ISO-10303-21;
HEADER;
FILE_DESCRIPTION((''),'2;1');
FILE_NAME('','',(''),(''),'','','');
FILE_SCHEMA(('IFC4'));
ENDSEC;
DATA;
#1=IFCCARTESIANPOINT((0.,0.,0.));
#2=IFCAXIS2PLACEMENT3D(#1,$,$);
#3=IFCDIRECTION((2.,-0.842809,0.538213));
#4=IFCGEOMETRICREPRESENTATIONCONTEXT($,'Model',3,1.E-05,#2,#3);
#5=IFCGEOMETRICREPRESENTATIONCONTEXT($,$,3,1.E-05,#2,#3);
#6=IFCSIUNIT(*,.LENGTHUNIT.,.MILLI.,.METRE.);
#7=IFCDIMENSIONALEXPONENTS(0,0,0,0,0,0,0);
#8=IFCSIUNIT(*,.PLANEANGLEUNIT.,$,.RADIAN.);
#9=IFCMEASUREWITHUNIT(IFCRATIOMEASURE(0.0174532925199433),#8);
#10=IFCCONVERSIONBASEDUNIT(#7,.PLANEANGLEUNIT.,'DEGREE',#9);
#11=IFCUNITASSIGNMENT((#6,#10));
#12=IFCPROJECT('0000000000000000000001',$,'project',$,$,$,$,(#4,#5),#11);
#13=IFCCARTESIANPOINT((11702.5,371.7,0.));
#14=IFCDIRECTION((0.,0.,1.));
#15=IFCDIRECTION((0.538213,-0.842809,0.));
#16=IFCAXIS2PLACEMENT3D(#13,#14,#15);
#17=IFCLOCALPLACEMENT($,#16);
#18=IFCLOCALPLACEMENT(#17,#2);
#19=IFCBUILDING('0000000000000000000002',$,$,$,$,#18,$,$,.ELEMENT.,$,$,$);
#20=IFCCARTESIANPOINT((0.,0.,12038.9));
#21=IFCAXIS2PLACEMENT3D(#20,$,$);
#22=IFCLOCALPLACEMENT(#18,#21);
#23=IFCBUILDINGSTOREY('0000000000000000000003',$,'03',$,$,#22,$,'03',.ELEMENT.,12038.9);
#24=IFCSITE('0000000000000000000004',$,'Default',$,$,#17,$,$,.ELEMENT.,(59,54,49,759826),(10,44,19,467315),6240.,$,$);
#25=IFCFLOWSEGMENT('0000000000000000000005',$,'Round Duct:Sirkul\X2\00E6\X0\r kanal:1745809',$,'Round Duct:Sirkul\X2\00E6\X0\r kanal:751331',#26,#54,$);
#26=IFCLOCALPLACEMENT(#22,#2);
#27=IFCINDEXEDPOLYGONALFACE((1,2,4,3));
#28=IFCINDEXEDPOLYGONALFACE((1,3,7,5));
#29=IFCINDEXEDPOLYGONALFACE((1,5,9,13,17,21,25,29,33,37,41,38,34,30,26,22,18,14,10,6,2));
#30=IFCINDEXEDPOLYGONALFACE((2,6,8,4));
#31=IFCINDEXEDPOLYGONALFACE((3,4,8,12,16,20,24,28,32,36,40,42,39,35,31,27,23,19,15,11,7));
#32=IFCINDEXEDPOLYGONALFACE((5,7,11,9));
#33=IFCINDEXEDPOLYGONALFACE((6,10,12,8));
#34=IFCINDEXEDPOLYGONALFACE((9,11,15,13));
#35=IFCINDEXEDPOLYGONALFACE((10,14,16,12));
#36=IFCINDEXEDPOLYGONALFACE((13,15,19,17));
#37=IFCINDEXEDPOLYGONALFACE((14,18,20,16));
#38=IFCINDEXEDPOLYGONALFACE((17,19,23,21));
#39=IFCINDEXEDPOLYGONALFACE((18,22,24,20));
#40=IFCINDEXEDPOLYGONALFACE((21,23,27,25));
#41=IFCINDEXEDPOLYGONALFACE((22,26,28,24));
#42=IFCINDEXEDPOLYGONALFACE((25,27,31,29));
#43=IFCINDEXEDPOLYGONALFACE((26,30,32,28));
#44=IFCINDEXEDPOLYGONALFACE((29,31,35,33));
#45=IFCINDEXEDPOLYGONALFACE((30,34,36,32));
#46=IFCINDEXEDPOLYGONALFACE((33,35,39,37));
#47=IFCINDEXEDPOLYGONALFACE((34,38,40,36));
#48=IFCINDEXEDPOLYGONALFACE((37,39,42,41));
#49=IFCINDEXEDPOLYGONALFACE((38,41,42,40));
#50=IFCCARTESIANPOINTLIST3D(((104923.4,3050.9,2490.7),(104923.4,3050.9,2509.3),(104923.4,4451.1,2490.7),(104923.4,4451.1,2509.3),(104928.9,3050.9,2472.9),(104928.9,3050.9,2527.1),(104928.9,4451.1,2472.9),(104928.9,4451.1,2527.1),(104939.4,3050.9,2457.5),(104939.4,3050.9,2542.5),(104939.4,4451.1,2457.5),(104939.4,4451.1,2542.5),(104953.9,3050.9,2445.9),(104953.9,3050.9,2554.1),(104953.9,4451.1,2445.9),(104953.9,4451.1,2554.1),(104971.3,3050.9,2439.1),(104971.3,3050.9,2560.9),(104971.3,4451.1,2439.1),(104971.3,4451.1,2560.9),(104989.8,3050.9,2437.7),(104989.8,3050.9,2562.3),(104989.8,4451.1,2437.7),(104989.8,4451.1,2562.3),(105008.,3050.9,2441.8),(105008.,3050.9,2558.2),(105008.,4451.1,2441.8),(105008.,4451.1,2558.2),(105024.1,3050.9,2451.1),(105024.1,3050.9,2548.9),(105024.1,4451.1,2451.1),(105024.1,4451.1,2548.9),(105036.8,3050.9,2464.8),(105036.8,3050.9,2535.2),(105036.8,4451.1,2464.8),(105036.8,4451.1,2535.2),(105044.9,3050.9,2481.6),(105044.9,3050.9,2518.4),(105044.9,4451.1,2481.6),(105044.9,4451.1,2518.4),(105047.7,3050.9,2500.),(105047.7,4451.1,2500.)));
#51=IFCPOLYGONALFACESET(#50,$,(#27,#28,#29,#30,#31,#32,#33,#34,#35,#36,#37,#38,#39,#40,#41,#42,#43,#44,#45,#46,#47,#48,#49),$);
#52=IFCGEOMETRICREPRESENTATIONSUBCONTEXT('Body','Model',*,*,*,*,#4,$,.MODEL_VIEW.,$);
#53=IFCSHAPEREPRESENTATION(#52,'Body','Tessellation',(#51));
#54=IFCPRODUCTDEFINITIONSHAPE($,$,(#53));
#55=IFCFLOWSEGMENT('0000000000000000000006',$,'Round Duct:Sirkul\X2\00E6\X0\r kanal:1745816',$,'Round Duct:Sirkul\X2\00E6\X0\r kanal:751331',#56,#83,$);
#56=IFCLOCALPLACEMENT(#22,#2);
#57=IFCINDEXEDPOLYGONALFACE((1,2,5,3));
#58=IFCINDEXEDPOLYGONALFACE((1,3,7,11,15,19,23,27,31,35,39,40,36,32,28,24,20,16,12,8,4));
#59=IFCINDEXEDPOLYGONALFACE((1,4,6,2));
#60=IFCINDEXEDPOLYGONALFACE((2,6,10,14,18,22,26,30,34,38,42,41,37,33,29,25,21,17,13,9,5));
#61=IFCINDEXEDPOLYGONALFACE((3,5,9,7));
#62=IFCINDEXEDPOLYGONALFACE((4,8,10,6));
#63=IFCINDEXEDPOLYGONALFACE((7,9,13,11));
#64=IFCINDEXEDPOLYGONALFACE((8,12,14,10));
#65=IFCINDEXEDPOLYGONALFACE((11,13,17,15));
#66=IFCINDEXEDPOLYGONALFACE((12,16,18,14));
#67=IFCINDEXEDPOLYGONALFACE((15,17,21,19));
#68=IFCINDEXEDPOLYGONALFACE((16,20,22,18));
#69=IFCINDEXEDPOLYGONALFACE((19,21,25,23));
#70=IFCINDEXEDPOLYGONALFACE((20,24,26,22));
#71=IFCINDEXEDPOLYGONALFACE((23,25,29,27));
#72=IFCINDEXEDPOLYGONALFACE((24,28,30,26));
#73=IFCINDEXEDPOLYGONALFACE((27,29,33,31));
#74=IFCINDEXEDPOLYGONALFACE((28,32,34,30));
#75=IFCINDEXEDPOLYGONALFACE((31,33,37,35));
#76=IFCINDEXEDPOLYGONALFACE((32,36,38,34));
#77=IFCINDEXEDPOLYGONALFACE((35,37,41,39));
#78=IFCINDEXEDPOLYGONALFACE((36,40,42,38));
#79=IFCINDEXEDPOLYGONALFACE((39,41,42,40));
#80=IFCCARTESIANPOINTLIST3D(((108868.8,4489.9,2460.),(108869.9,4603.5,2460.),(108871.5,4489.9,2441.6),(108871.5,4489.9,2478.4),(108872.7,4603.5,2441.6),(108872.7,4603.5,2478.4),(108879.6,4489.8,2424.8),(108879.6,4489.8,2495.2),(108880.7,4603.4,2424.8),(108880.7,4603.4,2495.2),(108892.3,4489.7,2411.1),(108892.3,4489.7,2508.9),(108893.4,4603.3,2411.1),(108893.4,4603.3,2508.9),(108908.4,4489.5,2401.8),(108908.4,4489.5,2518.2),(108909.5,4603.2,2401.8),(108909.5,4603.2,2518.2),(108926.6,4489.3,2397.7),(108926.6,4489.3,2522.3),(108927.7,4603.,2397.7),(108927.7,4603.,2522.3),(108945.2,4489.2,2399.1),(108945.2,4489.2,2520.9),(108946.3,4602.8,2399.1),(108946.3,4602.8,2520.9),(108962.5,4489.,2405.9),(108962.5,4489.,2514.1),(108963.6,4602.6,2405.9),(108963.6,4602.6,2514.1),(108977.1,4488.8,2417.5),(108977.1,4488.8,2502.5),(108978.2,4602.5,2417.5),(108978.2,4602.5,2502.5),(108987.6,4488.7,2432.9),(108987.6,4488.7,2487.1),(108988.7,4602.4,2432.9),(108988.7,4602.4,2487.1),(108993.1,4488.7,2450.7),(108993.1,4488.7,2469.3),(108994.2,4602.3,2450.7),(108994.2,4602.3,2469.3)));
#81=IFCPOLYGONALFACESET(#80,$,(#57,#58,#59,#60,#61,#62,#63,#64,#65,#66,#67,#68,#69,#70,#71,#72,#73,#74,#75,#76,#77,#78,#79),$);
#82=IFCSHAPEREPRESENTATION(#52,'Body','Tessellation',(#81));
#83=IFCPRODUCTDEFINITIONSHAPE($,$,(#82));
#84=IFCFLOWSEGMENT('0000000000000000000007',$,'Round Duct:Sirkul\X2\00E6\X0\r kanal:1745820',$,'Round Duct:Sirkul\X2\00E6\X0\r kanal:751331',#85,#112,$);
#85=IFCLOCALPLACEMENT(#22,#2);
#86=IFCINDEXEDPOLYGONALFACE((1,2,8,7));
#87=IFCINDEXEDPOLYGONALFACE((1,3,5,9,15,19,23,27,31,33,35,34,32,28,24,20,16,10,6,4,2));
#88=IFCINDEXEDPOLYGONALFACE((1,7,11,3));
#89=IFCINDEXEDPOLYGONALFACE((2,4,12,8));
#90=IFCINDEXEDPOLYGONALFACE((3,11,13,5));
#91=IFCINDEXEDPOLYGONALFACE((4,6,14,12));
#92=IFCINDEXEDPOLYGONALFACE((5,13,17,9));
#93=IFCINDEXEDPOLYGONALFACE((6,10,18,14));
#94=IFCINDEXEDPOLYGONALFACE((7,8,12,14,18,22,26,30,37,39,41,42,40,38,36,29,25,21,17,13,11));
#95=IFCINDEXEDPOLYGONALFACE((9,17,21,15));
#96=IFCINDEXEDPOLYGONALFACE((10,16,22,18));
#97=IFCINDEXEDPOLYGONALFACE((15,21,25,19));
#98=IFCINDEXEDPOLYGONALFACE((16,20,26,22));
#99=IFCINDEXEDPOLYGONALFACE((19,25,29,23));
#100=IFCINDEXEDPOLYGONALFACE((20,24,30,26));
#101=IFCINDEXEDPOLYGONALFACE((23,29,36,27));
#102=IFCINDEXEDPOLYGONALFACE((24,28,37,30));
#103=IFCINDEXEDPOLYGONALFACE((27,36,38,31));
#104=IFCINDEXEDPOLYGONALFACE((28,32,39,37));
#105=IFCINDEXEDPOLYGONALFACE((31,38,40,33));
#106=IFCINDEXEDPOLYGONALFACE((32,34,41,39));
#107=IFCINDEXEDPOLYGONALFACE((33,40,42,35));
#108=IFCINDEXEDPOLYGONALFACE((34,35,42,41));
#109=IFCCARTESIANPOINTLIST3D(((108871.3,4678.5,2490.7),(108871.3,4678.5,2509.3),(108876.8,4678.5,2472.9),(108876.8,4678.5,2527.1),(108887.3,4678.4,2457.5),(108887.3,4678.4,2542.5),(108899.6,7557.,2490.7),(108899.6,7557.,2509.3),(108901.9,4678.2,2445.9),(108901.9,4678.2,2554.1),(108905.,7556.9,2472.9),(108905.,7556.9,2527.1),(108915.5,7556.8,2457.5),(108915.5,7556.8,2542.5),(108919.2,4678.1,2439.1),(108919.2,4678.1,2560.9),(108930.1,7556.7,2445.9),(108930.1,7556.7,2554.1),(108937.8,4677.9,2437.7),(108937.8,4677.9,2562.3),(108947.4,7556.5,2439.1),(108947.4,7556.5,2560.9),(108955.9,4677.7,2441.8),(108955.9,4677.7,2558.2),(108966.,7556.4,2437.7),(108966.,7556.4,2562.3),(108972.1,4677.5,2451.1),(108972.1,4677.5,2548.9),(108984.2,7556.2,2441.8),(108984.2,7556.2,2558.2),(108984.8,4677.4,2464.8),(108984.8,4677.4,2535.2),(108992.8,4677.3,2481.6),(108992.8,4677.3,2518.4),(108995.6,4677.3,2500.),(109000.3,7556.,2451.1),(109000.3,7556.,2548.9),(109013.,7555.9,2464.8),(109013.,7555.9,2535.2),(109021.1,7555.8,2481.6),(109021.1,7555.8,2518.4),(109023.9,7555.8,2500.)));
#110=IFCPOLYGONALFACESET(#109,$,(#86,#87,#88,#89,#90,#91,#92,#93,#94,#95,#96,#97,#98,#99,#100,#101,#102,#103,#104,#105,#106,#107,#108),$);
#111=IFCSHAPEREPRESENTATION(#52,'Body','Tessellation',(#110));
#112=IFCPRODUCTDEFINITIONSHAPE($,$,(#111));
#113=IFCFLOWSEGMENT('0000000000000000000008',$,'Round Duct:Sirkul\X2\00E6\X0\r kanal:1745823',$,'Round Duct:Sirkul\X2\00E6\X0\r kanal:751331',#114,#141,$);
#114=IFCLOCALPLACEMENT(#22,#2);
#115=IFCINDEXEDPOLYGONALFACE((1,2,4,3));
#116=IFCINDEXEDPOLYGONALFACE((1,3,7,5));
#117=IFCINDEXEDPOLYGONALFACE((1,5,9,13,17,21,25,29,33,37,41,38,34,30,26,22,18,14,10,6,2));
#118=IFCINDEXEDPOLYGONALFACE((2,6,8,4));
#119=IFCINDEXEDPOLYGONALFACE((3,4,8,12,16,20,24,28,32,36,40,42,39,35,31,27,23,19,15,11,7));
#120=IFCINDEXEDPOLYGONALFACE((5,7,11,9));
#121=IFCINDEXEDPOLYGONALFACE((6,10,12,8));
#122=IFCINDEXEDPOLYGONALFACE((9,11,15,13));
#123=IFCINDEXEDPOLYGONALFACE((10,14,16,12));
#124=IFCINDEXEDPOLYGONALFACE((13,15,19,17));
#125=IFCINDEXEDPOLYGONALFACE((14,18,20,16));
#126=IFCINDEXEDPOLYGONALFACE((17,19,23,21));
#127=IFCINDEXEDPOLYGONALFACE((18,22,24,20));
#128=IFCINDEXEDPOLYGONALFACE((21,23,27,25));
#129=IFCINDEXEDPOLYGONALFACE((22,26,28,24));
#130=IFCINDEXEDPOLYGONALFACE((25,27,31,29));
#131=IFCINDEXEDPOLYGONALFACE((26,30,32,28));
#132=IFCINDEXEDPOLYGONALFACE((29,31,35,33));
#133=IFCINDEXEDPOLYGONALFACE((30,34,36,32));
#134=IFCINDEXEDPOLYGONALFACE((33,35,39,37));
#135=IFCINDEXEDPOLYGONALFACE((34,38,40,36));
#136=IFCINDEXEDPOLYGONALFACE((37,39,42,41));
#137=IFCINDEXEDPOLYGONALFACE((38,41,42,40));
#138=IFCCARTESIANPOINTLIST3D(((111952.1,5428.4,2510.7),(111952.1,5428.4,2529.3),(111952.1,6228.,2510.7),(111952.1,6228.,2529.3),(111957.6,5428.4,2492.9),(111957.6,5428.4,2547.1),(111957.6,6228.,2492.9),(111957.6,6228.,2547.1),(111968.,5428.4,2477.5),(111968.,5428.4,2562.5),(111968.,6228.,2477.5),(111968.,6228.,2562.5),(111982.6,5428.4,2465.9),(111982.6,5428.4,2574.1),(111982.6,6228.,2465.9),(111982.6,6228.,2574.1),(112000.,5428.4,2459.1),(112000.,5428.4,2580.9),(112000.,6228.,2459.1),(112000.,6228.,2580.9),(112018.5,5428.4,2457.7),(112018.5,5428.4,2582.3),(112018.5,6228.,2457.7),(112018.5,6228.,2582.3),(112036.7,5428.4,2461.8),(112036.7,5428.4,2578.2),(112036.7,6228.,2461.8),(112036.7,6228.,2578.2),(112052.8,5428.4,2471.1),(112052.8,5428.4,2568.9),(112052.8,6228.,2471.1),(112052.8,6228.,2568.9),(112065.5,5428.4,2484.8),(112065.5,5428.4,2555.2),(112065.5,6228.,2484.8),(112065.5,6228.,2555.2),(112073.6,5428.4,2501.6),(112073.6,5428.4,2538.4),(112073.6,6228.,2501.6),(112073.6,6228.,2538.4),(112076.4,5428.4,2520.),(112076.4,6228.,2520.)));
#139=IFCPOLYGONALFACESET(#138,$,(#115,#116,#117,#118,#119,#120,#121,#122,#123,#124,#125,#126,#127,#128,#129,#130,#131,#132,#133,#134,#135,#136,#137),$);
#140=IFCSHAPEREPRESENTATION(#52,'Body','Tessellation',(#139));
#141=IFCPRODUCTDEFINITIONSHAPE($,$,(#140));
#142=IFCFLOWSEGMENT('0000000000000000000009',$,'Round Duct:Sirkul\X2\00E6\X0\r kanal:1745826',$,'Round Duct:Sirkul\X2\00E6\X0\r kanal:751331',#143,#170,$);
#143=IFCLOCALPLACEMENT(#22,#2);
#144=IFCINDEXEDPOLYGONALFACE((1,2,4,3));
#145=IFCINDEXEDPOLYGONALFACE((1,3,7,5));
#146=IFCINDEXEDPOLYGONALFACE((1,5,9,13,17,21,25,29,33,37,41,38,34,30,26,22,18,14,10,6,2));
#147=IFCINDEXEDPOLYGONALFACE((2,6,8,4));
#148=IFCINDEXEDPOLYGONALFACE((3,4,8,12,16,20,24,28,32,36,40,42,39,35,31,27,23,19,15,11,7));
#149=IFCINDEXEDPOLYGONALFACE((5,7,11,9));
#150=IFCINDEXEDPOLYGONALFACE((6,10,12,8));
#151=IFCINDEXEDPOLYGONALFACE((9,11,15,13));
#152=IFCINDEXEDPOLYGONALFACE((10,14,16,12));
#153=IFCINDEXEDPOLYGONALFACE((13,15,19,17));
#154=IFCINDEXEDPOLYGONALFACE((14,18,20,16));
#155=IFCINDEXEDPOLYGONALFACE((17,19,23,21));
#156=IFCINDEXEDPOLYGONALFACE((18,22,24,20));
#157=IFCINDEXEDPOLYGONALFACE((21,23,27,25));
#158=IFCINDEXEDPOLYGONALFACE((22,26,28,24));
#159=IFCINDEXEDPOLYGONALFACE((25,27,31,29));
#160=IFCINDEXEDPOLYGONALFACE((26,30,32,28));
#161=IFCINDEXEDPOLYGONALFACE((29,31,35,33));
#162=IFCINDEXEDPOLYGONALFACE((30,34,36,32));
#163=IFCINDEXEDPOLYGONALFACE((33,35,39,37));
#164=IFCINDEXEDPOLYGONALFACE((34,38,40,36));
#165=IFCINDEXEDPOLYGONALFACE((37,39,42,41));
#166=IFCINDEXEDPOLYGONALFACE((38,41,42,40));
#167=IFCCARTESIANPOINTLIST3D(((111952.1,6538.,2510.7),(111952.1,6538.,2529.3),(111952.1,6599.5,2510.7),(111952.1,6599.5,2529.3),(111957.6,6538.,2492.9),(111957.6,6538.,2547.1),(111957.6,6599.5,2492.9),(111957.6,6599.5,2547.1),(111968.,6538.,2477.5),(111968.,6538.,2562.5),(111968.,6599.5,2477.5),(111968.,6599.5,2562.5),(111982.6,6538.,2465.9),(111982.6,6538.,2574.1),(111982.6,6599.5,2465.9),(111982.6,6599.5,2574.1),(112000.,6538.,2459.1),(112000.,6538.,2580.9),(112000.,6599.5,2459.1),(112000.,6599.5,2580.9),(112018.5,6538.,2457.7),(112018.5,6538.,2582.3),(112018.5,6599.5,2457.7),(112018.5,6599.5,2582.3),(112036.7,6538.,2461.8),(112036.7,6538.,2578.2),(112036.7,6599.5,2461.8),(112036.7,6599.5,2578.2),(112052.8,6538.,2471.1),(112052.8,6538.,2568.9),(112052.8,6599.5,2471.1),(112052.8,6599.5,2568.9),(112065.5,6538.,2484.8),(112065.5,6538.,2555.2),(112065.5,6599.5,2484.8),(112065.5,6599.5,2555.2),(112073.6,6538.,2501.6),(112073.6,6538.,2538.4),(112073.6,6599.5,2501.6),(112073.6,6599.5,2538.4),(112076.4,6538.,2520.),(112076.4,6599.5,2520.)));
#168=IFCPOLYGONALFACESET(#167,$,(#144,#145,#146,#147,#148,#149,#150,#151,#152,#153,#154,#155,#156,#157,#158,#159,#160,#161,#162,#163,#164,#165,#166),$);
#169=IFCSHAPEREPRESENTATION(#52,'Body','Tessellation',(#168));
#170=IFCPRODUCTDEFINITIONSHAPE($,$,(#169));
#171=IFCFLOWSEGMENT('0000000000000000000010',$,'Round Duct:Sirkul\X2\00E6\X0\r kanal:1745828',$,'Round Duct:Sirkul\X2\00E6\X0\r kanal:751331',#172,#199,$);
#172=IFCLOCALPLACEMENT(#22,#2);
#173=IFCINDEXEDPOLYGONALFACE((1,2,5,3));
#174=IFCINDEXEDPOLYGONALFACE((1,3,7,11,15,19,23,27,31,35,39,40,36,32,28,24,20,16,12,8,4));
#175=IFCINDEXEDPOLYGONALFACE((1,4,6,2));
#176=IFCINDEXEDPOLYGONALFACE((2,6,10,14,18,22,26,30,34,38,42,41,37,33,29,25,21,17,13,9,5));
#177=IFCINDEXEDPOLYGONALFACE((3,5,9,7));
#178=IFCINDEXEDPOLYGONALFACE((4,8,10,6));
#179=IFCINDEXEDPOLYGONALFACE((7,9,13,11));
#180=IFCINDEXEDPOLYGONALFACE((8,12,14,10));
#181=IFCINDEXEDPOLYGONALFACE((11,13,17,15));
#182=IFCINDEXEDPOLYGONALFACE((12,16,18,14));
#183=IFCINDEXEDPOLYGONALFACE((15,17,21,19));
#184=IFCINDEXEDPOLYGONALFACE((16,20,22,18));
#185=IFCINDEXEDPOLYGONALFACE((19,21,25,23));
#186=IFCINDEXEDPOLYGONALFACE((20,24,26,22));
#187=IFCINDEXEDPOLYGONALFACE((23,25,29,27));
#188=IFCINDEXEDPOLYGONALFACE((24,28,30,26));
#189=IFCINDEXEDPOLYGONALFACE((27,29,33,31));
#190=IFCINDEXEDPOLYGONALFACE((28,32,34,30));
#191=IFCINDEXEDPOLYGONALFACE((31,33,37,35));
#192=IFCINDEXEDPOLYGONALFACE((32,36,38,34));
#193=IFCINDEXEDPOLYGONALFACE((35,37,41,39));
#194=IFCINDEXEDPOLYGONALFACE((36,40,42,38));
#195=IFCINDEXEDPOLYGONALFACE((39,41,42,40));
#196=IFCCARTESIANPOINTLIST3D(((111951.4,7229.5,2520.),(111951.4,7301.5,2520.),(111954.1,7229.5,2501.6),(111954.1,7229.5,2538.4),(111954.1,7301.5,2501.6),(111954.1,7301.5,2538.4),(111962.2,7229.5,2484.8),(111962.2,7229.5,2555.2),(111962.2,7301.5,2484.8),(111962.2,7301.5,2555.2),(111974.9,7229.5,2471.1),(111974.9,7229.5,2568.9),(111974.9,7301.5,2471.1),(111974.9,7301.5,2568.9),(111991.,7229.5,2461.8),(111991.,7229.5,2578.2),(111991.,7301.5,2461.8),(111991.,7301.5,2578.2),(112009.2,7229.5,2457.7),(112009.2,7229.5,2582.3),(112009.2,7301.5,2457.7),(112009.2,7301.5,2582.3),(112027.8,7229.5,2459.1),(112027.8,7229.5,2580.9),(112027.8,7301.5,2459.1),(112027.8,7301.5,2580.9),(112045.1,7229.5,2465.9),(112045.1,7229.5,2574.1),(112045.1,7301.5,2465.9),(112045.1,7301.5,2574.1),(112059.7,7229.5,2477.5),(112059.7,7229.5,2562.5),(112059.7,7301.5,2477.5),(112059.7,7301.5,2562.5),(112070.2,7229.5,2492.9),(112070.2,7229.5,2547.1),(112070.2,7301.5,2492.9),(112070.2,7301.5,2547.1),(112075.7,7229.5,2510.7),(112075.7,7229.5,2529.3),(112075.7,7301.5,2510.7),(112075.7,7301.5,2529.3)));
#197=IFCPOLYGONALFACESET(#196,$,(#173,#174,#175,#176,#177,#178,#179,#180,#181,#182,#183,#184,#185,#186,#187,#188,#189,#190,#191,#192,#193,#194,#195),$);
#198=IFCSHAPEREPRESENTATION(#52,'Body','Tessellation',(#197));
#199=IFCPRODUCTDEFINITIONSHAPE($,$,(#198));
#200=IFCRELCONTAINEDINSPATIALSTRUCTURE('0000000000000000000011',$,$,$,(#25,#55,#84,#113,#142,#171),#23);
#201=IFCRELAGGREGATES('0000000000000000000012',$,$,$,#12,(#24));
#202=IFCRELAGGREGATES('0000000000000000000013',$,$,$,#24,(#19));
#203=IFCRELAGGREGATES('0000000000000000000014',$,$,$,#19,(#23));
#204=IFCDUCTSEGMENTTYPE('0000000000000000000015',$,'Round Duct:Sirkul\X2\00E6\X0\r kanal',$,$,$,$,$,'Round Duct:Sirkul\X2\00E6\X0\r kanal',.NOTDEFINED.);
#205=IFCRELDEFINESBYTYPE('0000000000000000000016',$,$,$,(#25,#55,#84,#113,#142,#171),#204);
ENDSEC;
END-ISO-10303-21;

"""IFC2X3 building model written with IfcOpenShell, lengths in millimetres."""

from ifc_helpers import new_model, entity, si_unit, converted_unit, direction, frame, frame_2d, origin, origin_2d_with_axis, place, context, subcontext, project, spatial, circle, extrude, type_object, element, save


model = new_model("IFC2X3")

# Units and contexts
model_context = context("Model", 3, precision=1e-05, world=origin(), true_north=direction((2.0, -0.842809, 0.538213)))
context_of_model = context(None, 3, precision=1e-05, world=origin(), true_north=direction((2.0, -0.842809, 0.538213)))
body_context = subcontext(model_context, "Body", "Model", "MODEL_VIEW")
ifc_project = project(units=[si_unit("LENGTHUNIT", "METRE", prefix="MILLI"), converted_unit("PLANEANGLEUNIT", "DEGREE", entity("IfcRatioMeasure", 0.0174532925199433), si_unit("PLANEANGLEUNIT", "RADIAN"), dimensions=[0, 0, 0, 0, 0, 0, 0])], contexts=[model_context, context_of_model])

# Site, building, storey
site_placement = place(None, frame((11702.5, 371.7, 0.0), z_axis=(0.0, 0.0, 1.0), x_axis=(0.538213, -0.842809, 0.0)))
site = spatial("IfcSite", under=ifc_project, at=site_placement, Name="Default", CompositionType="ELEMENT", RefLatitude=(59, 54, 49, 759826), RefLongitude=(10, 44, 19, 467315), RefElevation=6240.0)
building_placement = place(site_placement, origin())
building = spatial("IfcBuilding", under=site, at=building_placement, CompositionType="ELEMENT")
storey_placement = place(building_placement, frame((0.0, 0.0, 12038.9)))
storey = spatial("IfcBuildingStorey", under=building, at=storey_placement, Name="03", LongName="03", CompositionType="ELEMENT", Elevation=12038.9)

# Flow segments
duct_segment_type = type_object("IfcDuctSegmentType", Name="Round Duct:Sirkulær kanal", ElementType="Round Duct:Sirkulær kanal", PredefinedType="NOTDEFINED")
flow_segment_1_placement = place(storey_placement, origin())
element("IfcFlowSegment", 1, at=flow_segment_1_placement, inside=storey, type_object=duct_segment_type, Name="Round Duct:Sirkulær kanal:1745809", ObjectType="Round Duct:Sirkulær kanal:751331", context=body_context, shape_type="SweptSolid", body=[
    extrude(circle(Radius=62.5, at=origin_2d_with_axis()), frame((104985.2, 3050.9, 2500.0), z_axis=(0.0, 1.0, 0.0), x_axis=(1.0, 0.0, 0.0)), (0.0, 0.0, 1.0), 1400.2),
])
flow_segment_2_placement = place(storey_placement, origin())
element("IfcFlowSegment", 2, at=flow_segment_2_placement, inside=storey, type_object=duct_segment_type, Name="Round Duct:Sirkulær kanal:1745816", ObjectType="Round Duct:Sirkulær kanal:751331", context=body_context, shape_type="SweptSolid", body=[
    extrude(circle(Radius=62.5, at=origin_2d_with_axis()), frame((108931.3, 4489.3, 2460.0), z_axis=(0.00981, 0.999952, 0.0), x_axis=(-0.999952, 0.00981, 0.0)), (0.0, 0.0, 1.0), 113.7),
])
flow_segment_3_placement = place(storey_placement, origin())
element("IfcFlowSegment", 3, at=flow_segment_3_placement, inside=storey, type_object=duct_segment_type, Name="Round Duct:Sirkulær kanal:1745820", ObjectType="Round Duct:Sirkulær kanal:751331", context=body_context, shape_type="SweptSolid", body=[
    extrude(circle(Radius=62.5, at=origin_2d_with_axis()), frame((108933.1, 4677.9, 2500.0), z_axis=(0.00981, 0.999952, 0.0), x_axis=(0.999952, -0.00981, 0.0)), (0.0, 0.0, 1.0), 2878.6),
])
flow_segment_4_placement = place(storey_placement, origin())
element("IfcFlowSegment", 4, at=flow_segment_4_placement, inside=storey, type_object=duct_segment_type, Name="Round Duct:Sirkulær kanal:1745823", ObjectType="Round Duct:Sirkulær kanal:751331", context=body_context, shape_type="SweptSolid", body=[
    extrude(circle(Radius=62.5, at=frame_2d((0.0, 0.0), x_axis=(1.0, 0.0))), frame((112013.9, 5428.4, 2520.0), z_axis=(0.000003, 1.0, 0.0), x_axis=(1.0, -0.000003, 0.0)), (0.0, 0.0, 1.0), 799.6),
])
flow_segment_5_placement = place(storey_placement, origin())
element("IfcFlowSegment", 5, at=flow_segment_5_placement, inside=storey, type_object=duct_segment_type, Name="Round Duct:Sirkulær kanal:1745826", ObjectType="Round Duct:Sirkulær kanal:751331", context=body_context, shape_type="SweptSolid", body=[
    extrude(circle(Radius=62.5, at=frame_2d((0.0, 0.0), x_axis=(1.0, 0.0))), frame((112013.9, 6538.0, 2520.0), z_axis=(0.000003, 1.0, 0.0), x_axis=(1.0, -0.000003, 0.0)), (0.0, 0.0, 1.0), 61.5),
])
flow_segment_6_placement = place(storey_placement, origin())
element("IfcFlowSegment", 6, at=flow_segment_6_placement, inside=storey, type_object=duct_segment_type, Name="Round Duct:Sirkulær kanal:1745828", ObjectType="Round Duct:Sirkulær kanal:751331", context=body_context, shape_type="SweptSolid", body=[
    extrude(circle(Radius=62.5, at=origin_2d_with_axis()), frame((112013.9, 7229.5, 2520.0), z_axis=(0.000003, 1.0, 0.0), x_axis=(-1.0, 0.000003, 0.0)), (0.0, 0.0, 1.0), 72.0),
])

save(model, "model.ifc")
